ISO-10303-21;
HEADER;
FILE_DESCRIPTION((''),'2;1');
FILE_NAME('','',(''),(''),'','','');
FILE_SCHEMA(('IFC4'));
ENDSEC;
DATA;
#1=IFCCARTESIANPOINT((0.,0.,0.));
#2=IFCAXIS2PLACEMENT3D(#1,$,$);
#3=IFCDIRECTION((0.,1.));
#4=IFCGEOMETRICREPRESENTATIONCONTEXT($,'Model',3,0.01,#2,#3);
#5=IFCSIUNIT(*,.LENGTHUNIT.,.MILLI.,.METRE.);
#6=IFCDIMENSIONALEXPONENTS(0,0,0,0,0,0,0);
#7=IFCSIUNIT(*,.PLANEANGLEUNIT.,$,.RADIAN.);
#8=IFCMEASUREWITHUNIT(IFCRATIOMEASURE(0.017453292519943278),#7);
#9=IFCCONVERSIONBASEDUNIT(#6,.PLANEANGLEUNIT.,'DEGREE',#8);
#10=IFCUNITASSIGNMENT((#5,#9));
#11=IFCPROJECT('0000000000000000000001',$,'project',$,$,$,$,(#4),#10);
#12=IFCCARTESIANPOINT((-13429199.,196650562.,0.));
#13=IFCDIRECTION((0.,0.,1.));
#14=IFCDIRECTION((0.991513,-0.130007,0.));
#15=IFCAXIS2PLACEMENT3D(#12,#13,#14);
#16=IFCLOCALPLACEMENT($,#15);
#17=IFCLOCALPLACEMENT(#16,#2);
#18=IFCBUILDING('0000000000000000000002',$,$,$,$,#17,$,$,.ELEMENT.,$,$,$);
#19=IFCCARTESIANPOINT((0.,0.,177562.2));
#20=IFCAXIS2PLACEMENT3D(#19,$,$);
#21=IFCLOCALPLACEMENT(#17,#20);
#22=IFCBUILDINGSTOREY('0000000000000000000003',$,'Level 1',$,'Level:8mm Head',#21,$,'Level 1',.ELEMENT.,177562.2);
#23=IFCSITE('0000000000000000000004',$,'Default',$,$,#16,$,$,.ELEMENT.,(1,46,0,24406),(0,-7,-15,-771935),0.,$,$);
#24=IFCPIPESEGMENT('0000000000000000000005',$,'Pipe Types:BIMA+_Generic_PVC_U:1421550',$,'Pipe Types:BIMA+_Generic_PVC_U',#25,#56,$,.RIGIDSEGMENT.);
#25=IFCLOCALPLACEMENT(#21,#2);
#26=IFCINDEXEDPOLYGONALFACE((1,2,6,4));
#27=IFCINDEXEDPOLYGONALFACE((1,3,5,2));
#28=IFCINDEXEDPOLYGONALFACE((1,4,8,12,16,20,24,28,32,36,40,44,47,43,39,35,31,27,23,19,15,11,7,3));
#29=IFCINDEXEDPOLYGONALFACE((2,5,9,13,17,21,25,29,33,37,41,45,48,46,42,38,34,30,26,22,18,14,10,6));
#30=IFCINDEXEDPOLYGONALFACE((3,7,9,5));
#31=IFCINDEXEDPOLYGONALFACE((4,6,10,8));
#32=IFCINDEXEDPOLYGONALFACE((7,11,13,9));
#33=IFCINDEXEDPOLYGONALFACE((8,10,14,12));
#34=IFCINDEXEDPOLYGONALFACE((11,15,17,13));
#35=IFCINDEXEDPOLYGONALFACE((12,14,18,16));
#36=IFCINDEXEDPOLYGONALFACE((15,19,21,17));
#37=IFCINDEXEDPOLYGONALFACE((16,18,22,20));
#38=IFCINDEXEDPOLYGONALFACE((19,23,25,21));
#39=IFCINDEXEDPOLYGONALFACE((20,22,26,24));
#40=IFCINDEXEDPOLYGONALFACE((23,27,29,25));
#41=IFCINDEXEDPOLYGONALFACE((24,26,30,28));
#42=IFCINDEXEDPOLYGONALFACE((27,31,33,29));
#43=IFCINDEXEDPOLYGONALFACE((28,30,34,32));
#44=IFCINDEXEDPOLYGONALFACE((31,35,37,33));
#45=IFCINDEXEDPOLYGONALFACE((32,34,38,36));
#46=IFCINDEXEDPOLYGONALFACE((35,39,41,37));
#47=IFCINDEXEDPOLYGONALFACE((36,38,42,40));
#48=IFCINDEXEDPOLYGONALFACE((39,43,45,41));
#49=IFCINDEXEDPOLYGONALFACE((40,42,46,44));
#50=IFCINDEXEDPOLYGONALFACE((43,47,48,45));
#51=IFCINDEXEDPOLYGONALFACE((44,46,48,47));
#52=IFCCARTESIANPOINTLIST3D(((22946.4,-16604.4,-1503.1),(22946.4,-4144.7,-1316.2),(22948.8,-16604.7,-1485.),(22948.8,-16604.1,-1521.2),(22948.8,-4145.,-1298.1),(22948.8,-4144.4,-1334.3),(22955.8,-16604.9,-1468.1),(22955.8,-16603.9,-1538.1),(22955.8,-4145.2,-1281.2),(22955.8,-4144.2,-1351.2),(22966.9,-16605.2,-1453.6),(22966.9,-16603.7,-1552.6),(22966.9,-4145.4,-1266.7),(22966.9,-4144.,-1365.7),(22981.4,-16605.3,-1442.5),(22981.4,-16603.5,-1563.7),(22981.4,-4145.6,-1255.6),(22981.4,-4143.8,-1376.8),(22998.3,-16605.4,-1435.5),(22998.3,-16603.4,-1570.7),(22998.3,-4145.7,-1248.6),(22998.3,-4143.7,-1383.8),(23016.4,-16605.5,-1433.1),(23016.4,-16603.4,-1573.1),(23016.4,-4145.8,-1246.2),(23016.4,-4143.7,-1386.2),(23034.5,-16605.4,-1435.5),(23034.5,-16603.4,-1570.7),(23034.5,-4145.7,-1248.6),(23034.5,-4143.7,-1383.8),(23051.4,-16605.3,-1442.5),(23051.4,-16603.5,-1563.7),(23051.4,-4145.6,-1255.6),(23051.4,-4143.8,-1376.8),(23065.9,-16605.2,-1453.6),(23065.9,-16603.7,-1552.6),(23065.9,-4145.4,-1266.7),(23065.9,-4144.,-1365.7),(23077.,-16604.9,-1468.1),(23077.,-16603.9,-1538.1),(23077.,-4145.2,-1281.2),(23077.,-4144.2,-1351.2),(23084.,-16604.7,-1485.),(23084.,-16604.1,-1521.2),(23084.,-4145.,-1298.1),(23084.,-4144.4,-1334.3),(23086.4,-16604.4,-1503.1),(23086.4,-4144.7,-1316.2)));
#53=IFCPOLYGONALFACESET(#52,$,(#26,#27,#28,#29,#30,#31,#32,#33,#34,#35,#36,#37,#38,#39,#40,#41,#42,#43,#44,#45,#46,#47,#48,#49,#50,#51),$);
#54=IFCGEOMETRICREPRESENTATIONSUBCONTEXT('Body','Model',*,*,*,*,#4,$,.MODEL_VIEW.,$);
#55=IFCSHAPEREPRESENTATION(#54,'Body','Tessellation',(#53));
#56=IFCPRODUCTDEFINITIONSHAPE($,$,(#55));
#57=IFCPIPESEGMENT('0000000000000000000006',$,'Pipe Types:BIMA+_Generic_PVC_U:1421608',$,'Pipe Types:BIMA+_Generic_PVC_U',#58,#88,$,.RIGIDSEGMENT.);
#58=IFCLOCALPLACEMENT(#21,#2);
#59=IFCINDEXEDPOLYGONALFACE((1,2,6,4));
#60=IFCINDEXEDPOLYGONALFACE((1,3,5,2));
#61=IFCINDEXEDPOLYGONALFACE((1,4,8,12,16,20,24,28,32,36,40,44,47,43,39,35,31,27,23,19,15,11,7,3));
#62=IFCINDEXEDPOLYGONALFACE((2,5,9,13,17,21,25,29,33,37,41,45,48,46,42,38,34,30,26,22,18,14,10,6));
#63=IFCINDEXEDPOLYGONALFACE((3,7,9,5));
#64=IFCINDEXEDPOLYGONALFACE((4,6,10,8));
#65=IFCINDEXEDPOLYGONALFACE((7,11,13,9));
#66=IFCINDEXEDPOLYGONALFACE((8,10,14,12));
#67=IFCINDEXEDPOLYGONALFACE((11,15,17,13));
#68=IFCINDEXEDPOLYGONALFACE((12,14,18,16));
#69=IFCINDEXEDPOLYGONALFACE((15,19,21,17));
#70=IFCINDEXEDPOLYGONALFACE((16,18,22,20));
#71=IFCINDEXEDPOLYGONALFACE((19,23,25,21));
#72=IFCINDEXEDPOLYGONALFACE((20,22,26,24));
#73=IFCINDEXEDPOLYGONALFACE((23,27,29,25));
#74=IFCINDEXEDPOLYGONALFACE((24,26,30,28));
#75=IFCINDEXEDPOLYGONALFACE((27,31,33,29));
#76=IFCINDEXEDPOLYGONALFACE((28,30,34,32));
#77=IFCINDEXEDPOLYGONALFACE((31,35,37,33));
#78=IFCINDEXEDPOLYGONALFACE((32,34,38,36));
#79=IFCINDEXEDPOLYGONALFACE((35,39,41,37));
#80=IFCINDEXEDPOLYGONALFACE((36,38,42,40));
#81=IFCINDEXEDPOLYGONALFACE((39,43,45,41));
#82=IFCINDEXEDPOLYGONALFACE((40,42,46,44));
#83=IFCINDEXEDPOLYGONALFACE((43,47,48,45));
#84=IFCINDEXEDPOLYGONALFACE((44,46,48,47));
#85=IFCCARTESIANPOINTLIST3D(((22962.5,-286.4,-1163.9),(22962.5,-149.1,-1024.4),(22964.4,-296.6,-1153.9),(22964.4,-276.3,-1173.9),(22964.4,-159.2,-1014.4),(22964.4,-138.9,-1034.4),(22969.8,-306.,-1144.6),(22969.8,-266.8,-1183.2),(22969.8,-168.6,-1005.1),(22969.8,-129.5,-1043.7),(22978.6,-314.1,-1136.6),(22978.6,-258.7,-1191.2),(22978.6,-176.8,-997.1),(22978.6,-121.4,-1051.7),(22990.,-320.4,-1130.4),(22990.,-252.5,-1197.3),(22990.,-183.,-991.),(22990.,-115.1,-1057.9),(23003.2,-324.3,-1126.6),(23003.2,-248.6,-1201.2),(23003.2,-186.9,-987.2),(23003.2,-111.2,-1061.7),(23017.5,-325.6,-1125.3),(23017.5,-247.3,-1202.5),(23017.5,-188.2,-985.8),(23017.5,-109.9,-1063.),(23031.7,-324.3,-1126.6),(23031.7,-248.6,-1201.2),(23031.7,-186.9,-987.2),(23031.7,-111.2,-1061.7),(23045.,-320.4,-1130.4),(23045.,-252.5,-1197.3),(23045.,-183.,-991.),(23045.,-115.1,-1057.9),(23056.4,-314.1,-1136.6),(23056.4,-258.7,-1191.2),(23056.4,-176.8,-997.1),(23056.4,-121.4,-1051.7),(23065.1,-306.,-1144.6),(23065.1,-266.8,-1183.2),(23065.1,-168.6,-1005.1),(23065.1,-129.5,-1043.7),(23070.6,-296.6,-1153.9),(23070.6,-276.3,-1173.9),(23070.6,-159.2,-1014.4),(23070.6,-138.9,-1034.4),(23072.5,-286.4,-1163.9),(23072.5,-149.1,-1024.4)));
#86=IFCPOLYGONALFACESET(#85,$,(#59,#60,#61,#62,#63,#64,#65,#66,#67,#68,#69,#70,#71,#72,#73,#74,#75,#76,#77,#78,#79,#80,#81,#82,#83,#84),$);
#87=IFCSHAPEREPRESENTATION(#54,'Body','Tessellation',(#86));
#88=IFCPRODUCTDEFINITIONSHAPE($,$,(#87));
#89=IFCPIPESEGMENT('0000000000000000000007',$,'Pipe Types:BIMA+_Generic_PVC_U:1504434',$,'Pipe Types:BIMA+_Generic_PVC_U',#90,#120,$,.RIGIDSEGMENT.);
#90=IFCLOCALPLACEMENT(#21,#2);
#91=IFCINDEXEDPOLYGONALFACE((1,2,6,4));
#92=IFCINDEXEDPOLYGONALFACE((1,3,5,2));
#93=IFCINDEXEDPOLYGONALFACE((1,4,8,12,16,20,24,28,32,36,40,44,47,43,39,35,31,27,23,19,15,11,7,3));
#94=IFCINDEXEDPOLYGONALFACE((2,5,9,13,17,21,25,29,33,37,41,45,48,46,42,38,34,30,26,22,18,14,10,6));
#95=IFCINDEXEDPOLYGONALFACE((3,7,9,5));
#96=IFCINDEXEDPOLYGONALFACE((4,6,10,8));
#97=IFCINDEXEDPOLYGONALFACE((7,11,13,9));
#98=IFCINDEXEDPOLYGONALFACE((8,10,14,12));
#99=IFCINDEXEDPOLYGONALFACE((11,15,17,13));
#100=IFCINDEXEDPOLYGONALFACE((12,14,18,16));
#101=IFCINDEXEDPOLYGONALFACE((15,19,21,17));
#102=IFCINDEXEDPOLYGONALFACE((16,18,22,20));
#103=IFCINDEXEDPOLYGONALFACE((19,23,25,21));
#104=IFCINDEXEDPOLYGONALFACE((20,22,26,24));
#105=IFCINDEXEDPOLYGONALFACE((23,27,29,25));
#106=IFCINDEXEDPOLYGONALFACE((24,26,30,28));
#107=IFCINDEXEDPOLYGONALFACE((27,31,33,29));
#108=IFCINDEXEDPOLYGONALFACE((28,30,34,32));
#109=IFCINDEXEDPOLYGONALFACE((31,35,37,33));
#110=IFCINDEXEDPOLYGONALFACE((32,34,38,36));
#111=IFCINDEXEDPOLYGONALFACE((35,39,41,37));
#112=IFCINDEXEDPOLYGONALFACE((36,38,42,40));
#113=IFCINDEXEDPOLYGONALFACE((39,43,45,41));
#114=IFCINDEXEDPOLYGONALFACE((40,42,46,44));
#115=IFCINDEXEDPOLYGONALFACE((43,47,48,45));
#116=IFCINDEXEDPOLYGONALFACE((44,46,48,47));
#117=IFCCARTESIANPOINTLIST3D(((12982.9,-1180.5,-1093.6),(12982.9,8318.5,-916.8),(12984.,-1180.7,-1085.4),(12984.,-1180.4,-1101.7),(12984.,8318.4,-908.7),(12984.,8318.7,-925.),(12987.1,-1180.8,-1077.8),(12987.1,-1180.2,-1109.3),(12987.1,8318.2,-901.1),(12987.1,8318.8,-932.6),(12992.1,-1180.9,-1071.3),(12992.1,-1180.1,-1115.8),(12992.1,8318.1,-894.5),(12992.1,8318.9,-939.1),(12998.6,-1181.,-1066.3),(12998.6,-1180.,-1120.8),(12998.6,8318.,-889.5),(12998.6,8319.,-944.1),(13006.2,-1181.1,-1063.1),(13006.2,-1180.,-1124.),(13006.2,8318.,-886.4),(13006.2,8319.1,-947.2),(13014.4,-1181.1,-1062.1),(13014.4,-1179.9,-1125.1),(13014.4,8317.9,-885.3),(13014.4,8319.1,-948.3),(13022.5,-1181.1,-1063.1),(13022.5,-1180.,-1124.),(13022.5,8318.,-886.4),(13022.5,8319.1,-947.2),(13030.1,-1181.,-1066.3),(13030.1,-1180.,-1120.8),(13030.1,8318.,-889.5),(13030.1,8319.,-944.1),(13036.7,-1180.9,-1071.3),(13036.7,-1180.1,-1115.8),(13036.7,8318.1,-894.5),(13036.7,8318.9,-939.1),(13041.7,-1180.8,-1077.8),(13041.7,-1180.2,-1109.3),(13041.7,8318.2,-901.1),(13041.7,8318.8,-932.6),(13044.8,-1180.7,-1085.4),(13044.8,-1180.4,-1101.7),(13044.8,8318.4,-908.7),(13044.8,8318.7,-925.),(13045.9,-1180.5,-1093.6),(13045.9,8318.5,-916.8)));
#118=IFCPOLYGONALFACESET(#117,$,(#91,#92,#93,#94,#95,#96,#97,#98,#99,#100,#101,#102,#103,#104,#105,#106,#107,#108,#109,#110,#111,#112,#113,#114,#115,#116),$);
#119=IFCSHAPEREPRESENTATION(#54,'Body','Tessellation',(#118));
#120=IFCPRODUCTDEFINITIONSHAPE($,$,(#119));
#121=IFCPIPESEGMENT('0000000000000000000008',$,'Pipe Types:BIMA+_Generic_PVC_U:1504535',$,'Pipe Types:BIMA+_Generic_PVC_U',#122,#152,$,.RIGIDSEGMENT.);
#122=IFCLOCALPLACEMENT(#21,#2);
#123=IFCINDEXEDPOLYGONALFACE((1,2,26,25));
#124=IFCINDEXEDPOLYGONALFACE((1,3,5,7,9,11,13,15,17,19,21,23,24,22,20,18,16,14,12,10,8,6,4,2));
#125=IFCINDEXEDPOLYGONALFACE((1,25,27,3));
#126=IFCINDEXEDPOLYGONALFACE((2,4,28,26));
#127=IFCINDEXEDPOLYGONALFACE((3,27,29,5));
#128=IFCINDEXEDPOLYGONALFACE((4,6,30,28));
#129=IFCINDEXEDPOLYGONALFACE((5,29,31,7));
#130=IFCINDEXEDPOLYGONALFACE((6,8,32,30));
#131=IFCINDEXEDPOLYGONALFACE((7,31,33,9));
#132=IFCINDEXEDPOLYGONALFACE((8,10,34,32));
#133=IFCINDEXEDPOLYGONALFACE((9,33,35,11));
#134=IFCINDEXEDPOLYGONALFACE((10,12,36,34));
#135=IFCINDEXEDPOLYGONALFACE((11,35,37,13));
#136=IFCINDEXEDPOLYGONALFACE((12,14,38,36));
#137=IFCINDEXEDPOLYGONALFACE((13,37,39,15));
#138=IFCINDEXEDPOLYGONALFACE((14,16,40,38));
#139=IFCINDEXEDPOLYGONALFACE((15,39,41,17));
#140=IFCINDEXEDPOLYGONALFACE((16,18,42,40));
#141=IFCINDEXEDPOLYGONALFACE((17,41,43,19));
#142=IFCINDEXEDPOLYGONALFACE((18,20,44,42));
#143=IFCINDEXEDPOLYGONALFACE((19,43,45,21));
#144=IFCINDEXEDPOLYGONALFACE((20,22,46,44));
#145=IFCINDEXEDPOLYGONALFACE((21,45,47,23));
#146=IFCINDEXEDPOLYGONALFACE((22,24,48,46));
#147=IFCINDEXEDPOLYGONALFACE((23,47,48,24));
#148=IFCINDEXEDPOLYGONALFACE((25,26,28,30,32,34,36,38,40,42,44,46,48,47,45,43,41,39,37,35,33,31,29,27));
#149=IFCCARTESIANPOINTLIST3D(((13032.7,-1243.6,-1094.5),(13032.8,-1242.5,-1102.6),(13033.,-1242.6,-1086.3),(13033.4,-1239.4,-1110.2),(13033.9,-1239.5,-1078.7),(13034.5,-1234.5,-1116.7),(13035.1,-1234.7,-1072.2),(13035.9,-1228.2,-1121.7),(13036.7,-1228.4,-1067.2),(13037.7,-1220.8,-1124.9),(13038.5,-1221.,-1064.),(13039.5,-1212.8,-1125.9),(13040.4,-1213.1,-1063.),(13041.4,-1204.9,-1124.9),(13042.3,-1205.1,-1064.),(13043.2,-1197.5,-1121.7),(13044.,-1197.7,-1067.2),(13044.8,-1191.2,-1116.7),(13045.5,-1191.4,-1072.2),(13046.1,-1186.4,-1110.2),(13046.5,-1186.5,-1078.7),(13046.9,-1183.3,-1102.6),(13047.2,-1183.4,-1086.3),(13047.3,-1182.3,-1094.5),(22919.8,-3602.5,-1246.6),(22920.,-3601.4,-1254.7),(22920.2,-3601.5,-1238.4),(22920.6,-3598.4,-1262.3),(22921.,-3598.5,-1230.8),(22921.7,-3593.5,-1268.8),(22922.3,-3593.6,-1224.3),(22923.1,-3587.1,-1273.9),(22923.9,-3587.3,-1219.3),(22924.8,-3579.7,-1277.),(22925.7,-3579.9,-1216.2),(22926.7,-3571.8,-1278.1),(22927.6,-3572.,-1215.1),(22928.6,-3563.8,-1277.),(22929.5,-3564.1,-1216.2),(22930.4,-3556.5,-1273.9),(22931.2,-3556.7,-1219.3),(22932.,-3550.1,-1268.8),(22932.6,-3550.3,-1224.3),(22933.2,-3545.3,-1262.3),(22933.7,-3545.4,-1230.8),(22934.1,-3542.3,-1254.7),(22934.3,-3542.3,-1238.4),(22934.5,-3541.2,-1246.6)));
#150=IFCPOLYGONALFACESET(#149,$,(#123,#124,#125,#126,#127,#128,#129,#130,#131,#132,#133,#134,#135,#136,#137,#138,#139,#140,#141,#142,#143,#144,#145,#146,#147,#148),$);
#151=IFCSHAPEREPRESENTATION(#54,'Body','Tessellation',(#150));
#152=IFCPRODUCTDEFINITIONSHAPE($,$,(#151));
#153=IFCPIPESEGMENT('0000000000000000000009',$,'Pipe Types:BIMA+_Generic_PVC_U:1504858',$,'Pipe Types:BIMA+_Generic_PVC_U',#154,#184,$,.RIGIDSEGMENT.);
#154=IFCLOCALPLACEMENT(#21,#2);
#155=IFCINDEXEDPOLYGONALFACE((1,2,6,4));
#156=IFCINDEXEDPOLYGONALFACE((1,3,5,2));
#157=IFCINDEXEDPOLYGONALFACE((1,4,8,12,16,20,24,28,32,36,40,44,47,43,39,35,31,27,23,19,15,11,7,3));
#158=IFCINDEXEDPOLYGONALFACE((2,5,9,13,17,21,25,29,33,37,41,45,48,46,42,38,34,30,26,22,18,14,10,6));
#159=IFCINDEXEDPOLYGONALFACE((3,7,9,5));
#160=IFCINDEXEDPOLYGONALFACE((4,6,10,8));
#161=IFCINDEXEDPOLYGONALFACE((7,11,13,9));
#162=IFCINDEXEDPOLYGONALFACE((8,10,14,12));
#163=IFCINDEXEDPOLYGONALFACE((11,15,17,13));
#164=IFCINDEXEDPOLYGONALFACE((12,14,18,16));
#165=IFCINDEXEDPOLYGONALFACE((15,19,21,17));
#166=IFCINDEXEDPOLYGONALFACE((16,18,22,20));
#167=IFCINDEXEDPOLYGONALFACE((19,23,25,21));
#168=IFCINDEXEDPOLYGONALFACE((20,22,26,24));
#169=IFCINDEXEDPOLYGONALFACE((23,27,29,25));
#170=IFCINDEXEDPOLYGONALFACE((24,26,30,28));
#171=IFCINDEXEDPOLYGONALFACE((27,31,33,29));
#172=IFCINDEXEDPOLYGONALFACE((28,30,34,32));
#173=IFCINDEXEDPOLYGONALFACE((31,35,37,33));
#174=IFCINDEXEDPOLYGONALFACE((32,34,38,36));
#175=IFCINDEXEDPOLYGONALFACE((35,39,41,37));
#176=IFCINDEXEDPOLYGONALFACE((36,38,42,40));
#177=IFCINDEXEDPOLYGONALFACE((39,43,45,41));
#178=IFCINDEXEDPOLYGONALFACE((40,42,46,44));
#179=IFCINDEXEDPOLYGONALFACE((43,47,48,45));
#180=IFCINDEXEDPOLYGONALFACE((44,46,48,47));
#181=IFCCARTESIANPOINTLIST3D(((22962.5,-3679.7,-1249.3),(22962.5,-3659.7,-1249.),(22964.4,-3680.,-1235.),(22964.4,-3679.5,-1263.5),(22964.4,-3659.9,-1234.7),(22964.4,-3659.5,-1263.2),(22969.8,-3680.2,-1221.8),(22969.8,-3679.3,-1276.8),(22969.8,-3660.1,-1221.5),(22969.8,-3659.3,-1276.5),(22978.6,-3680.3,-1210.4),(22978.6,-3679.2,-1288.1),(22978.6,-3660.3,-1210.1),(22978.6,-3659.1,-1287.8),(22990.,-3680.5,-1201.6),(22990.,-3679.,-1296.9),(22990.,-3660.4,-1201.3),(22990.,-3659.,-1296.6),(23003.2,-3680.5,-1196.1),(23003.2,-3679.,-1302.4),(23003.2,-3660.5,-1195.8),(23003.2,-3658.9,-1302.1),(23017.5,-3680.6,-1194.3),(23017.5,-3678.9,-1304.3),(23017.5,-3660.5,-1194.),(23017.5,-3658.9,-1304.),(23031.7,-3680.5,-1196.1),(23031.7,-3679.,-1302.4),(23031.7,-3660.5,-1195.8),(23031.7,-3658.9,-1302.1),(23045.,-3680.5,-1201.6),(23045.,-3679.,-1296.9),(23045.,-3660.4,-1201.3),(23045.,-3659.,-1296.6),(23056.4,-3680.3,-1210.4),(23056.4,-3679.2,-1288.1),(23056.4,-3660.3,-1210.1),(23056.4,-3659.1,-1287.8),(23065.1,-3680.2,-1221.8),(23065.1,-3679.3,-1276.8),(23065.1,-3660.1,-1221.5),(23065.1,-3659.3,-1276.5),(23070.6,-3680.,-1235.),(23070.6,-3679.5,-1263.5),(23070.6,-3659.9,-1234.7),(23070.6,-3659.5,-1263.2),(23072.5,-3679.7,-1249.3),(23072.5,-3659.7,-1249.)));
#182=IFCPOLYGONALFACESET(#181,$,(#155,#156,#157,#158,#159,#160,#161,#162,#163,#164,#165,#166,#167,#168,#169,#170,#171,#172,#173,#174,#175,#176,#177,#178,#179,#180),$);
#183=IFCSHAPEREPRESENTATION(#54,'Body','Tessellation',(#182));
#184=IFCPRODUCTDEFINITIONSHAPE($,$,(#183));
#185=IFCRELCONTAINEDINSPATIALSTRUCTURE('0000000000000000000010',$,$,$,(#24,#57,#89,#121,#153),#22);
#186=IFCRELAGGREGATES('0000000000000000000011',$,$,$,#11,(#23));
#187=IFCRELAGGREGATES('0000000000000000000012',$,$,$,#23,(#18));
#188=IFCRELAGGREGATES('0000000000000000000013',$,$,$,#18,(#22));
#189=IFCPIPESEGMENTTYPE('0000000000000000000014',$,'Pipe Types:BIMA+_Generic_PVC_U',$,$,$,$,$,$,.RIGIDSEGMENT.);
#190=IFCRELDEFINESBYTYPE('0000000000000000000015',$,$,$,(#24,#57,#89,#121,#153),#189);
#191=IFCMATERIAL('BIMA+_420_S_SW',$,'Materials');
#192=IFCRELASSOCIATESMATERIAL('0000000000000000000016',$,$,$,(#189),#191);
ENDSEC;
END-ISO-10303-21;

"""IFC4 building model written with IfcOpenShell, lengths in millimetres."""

from ifc_helpers import new_model, entity, si_unit, converted_unit, direction, frame, origin, place, context, subcontext, project, spatial, arc, indexed_curve, outline, extrude, material, type_object, element, save


model = new_model("IFC4")

# Units and contexts
model_context = context("Model", 3, precision=0.01, world=origin(), true_north=direction((0.0, 1.0)))
body_context = subcontext(model_context, "Body", "Model", "MODEL_VIEW")
ifc_project = project(units=[si_unit("LENGTHUNIT", "METRE", prefix="MILLI"), converted_unit("PLANEANGLEUNIT", "DEGREE", entity("IfcRatioMeasure", 0.017453292519943278), si_unit("PLANEANGLEUNIT", "RADIAN"), dimensions=[0, 0, 0, 0, 0, 0, 0])], contexts=[model_context])

# Site, building, storey
site_placement = place(None, frame((-13429199.0, 196650562.0, 0.0), z_axis=(0.0, 0.0, 1.0), x_axis=(0.991513, -0.130007, 0.0)))
site = spatial("IfcSite", under=ifc_project, at=site_placement, Name="Default", CompositionType="ELEMENT", RefLatitude=(1, 46, 0, 24406), RefLongitude=(0, -7, -15, -771935), RefElevation=0.0)
building_placement = place(site_placement, origin())
building = spatial("IfcBuilding", under=site, at=building_placement, CompositionType="ELEMENT")
storey_placement = place(building_placement, frame((0.0, 0.0, 177562.2)))
storey = spatial("IfcBuildingStorey", under=building, at=storey_placement, Name="Level 1", ObjectType="Level:8mm Head", LongName="Level 1", CompositionType="ELEMENT", Elevation=177562.2)

# Pipe segments
ifc_material_1 = material(Name="BIMA+_420_S_SW", Category="Materials")
pipe_segment_type_1 = type_object("IfcPipeSegmentType", Name="Pipe Types:BIMA+_Generic_PVC_U", PredefinedType="RIGIDSEGMENT", material=ifc_material_1)
pipe_segment_1_placement = place(storey_placement, frame((22944.8, -16607.1, -1574.7)))
element("IfcPipeSegment", 1, at=pipe_segment_1_placement, inside=storey, type_object=pipe_segment_type_1, Name="Pipe Types:BIMA+_Generic_PVC_U:1421550", ObjectType="Pipe Types:BIMA+_Generic_PVC_U", PredefinedType="RIGIDSEGMENT", context=body_context, shape_type="SweptSolid", body=[
    extrude(outline(indexed_curve([(70.0, 0.0), (49.5, 49.5), (0.0, 70.0), (-49.5, 49.5), (-70.0, 0.0), (-49.5, -49.5), (0.0, -70.0), (49.5, -49.5)], segments=[arc(1, 2, 3), arc(3, 4, 5), arc(5, 6, 7), arc(7, 8, 1)], self_intersect=False)), frame((71.6, 2.6, 71.6), z_axis=(0.0, 0.999888, 0.014998), x_axis=(-1.0, 0.0, 0.0)), (0.0, 0.0, 1.0), 12461.1),
])
pipe_segment_2_placement = place(storey_placement, frame((22960.9, -327.2, -1204.1)))
element("IfcPipeSegment", 2, at=pipe_segment_2_placement, inside=storey, type_object=pipe_segment_type_1, Name="Pipe Types:BIMA+_Generic_PVC_U:1421608", ObjectType="Pipe Types:BIMA+_Generic_PVC_U", PredefinedType="RIGIDSEGMENT", context=body_context, shape_type="SweptSolid", body=[
    extrude(outline(indexed_curve([(55.0, 0.0), (38.9, 38.9), (0.0, 55.0), (-38.9, 38.9), (-55.0, 0.0), (-38.9, -38.9), (0.0, -55.0), (38.9, -38.9)], segments=[arc(1, 2, 3), arc(3, 4, 5), arc(5, 6, 7), arc(7, 8, 1)], self_intersect=False)), frame((56.6, 40.8, 40.2), z_axis=(0.0, 0.701823, 0.712351), x_axis=(1.0, 0.0, 0.0)), (0.0, 0.0, 1.0), 195.7),
])
pipe_segment_3_placement = place(storey_placement, frame((12981.3, -1182.7, -883.7)))
element("IfcPipeSegment", 3, at=pipe_segment_3_placement, inside=storey, type_object=pipe_segment_type_1, Name="Pipe Types:BIMA+_Generic_PVC_U:1504434", ObjectType="Pipe Types:BIMA+_Generic_PVC_U", PredefinedType="RIGIDSEGMENT", context=body_context, shape_type="SweptSolid", body=[
    extrude(outline(indexed_curve([(31.5, 0.0), (22.3, 22.3), (0.0, 31.5), (-22.3, 22.3), (-31.5, 0.0), (-22.3, -22.3), (0.0, -31.5), (22.3, -22.3)], segments=[arc(1, 2, 3), arc(3, 4, 5), arc(5, 6, 7), arc(7, 8, 1)], self_intersect=False)), frame((33.1, 2.2, -209.8), z_axis=(-0.000001, 0.999827, 0.018605), x_axis=(-1.0, -0.000001, 0.0)), (0.0, 0.0, 1.0), 9500.7),
])
pipe_segment_4_placement = place(storey_placement, frame((13031.1, -3604.1, -1061.4)))
element("IfcPipeSegment", 4, at=pipe_segment_4_placement, inside=storey, type_object=pipe_segment_type_1, Name="Pipe Types:BIMA+_Generic_PVC_U:1504535", ObjectType="Pipe Types:BIMA+_Generic_PVC_U", PredefinedType="RIGIDSEGMENT", context=body_context, shape_type="SweptSolid", body=[
    extrude(outline(indexed_curve([(31.5, 0.0), (22.3, 22.3), (0.0, 31.5), (-22.3, 22.3), (-31.5, 0.0), (-22.3, -22.3), (0.0, -31.5), (22.3, -22.3)], segments=[arc(1, 2, 3), arc(3, 4, 5), arc(5, 6, 7), arc(7, 8, 1)], self_intersect=False)), frame((9896.1, 32.2, -185.2), z_axis=(-0.97259, 0.232046, 0.014964), x_axis=(0.232072, 0.972699, 0.0)), (0.0, 0.0, 1.0), 10165.8),
])
pipe_segment_5_placement = place(storey_placement, frame((22960.9, -3682.2, -1305.8)))
element("IfcPipeSegment", 5, at=pipe_segment_5_placement, inside=storey, type_object=pipe_segment_type_1, Name="Pipe Types:BIMA+_Generic_PVC_U:1504858", ObjectType="Pipe Types:BIMA+_Generic_PVC_U", PredefinedType="RIGIDSEGMENT", context=body_context, shape_type="SweptSolid", body=[
    extrude(outline(indexed_curve([(55.0, 0.0), (38.9, 38.9), (0.0, 55.0), (-38.9, 38.9), (-55.0, 0.0), (-38.9, -38.9), (0.0, -55.0), (38.9, -38.9)], segments=[arc(1, 2, 3), arc(3, 4, 5), arc(5, 6, 7), arc(7, 8, 1)], self_intersect=False)), frame((56.6, 2.4, 56.6), z_axis=(0.0, 0.999888, 0.014998), x_axis=(-1.0, 0.0, 0.0)), (0.0, 0.0, 1.0), 20.0),
])

save(model, "model.ifc")
